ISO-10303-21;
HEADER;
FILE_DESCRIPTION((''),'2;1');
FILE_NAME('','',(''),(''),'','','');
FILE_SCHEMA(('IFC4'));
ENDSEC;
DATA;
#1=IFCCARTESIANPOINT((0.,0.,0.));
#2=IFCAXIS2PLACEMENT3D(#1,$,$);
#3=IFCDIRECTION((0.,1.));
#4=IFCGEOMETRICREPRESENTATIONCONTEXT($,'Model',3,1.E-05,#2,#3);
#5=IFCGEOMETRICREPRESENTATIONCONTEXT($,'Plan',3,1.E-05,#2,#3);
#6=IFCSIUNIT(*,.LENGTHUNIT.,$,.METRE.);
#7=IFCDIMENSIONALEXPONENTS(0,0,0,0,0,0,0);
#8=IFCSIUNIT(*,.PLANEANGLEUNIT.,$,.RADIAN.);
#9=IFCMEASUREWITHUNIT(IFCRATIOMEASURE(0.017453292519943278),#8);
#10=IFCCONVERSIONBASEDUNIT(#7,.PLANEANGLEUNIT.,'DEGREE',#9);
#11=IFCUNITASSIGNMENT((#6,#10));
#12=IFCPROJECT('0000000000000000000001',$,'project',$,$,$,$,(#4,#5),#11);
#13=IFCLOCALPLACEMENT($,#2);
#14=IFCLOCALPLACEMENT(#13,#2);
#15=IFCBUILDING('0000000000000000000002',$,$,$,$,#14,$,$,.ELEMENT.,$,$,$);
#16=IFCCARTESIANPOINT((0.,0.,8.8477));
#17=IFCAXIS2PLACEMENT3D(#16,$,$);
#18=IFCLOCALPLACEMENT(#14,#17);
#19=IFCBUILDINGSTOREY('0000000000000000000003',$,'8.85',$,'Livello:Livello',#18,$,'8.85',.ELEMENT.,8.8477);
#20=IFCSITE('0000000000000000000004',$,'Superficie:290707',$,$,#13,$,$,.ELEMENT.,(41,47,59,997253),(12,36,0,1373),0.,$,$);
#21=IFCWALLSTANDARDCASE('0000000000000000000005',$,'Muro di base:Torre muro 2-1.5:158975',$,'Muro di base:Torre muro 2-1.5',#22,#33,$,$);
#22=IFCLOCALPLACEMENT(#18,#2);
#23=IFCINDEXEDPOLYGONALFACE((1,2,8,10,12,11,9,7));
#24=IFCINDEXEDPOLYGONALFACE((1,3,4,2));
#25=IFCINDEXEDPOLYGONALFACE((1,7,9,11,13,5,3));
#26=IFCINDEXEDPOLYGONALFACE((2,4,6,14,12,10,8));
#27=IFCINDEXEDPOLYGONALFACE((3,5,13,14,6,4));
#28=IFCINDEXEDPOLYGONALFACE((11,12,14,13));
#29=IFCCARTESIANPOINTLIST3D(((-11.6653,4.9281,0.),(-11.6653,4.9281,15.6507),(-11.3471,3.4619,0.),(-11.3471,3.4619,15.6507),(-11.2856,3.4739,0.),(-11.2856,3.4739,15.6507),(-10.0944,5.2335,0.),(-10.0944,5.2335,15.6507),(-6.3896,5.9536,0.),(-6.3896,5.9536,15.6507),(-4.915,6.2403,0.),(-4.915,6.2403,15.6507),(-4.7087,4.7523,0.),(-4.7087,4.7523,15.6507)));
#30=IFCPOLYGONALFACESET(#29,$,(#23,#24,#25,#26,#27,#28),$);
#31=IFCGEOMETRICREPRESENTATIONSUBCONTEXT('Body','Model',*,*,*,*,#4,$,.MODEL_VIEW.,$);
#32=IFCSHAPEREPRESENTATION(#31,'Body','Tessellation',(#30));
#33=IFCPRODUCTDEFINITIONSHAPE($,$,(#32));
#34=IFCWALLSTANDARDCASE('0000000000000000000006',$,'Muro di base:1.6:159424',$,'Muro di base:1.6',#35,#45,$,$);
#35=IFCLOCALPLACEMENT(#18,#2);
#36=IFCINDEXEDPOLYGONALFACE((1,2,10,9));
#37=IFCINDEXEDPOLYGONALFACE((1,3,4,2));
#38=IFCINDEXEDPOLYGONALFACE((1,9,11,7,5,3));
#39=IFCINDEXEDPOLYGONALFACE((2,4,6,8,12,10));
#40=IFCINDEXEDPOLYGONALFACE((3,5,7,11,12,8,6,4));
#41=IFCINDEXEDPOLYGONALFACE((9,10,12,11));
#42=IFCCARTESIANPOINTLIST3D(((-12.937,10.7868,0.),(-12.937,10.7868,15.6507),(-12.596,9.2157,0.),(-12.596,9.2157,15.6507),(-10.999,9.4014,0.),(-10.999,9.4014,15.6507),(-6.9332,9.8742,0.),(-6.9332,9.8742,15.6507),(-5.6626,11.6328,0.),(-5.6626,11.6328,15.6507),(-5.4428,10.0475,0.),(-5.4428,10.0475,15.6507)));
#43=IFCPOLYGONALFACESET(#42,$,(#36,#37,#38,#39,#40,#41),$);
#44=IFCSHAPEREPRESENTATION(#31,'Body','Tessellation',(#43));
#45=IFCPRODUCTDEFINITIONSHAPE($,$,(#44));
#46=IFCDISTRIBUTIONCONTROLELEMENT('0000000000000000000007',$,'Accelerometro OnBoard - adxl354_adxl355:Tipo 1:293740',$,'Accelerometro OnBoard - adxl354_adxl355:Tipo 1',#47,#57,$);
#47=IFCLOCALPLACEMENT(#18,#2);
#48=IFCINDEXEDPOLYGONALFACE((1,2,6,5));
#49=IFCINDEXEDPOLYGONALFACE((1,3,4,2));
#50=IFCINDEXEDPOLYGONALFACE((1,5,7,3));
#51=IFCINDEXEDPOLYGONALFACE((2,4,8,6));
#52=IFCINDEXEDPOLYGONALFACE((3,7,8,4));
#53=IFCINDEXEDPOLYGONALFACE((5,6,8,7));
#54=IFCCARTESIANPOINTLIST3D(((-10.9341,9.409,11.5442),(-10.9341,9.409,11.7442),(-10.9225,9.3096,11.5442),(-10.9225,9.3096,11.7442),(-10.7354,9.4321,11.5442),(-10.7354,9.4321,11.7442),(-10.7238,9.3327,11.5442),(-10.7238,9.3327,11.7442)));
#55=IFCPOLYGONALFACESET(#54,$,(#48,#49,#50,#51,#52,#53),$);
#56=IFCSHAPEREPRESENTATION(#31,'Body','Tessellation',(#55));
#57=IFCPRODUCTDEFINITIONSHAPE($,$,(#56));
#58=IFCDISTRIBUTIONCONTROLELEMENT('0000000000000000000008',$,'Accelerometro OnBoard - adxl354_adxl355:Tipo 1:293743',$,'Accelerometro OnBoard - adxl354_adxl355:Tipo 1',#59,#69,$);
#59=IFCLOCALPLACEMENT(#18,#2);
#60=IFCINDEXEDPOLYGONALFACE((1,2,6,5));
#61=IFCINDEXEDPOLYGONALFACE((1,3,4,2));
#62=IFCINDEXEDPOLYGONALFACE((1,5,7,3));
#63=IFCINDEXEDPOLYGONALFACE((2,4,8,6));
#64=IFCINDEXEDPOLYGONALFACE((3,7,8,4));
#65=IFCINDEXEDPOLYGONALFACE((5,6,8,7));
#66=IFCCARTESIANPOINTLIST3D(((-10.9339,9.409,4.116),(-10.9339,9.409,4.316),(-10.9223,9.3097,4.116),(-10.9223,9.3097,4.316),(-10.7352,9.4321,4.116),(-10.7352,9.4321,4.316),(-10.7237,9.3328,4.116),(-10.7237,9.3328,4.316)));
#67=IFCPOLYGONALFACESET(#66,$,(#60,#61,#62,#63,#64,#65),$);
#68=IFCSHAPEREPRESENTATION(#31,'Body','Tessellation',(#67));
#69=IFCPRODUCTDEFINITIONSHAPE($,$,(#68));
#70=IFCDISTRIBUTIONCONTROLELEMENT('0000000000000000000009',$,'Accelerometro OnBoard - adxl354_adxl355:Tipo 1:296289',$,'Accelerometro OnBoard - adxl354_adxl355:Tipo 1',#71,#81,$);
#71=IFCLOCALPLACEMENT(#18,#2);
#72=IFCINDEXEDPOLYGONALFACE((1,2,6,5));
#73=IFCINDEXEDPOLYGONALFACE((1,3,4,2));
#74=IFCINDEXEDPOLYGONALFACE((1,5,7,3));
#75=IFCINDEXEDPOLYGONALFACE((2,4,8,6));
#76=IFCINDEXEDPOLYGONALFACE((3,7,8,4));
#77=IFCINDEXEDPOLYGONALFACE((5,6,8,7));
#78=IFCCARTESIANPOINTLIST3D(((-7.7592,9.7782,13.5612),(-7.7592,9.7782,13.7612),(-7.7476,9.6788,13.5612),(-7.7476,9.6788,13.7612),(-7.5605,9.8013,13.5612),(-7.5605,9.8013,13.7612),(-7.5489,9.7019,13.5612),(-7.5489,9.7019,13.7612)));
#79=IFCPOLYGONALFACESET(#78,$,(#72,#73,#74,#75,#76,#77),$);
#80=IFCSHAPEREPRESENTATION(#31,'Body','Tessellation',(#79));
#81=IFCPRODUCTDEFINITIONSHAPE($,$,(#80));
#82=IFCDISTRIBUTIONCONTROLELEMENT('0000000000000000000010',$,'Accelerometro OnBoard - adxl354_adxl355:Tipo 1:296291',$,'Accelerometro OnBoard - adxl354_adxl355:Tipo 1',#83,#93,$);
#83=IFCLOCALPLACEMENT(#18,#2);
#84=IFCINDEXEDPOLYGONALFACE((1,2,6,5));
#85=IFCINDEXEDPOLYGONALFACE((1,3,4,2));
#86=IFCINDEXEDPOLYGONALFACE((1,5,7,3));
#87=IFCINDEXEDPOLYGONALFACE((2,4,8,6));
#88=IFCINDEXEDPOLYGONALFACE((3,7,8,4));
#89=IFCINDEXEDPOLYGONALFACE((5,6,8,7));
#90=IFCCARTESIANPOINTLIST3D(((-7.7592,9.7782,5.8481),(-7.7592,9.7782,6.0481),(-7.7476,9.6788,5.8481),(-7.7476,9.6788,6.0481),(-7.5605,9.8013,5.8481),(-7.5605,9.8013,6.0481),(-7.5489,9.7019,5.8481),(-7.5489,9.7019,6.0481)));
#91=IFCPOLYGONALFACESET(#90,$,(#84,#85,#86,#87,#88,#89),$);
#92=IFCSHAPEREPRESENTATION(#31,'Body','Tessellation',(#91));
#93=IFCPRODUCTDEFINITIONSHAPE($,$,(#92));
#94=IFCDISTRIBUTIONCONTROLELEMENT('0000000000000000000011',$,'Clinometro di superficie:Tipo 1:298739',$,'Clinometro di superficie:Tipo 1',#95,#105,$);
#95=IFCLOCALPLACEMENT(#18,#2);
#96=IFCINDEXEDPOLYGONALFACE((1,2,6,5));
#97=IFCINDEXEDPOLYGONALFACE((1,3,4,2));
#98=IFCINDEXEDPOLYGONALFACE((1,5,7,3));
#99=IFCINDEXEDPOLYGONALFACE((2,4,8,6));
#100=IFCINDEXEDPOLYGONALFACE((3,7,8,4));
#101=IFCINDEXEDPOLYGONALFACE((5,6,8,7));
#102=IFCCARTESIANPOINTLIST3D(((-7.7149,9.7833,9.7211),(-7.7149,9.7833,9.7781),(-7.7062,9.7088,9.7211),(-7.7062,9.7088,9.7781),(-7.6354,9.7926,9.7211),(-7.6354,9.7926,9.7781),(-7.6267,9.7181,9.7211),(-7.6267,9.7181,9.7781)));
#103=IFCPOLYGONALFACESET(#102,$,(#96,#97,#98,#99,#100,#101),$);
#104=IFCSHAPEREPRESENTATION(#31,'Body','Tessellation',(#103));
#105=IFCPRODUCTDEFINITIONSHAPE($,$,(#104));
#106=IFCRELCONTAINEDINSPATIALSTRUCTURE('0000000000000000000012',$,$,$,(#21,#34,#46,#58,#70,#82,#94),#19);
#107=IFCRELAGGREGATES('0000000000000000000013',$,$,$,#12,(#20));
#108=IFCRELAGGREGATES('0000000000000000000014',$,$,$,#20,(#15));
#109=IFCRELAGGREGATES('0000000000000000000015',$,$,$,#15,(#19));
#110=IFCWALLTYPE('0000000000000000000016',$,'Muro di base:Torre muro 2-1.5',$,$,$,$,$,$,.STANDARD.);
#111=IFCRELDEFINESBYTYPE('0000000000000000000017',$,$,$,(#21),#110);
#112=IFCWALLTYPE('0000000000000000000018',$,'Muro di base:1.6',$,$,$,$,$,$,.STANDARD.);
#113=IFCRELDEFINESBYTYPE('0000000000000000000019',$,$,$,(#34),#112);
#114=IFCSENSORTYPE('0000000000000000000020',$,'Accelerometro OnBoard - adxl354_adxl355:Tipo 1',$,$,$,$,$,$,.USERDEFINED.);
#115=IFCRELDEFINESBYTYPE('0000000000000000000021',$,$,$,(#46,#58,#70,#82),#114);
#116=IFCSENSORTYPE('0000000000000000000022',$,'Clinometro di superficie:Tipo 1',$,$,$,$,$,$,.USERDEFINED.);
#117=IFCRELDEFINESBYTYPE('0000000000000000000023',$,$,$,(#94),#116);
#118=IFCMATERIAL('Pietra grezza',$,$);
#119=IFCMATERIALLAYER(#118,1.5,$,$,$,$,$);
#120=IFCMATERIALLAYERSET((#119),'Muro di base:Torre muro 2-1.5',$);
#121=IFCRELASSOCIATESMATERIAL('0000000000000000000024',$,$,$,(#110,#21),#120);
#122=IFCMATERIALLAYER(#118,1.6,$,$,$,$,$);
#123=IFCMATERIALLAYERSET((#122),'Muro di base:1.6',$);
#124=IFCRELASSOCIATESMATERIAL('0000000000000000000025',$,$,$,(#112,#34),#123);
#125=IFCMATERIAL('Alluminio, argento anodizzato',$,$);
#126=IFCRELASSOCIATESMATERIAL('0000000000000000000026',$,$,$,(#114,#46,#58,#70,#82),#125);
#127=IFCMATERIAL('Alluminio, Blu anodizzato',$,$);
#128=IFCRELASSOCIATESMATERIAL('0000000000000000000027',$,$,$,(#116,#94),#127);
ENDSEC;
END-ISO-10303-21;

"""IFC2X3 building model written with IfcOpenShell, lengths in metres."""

from ifc_helpers import new_model, entity, si_unit, converted_unit, direction, frame, frame_2d, origin, place, context, subcontext, project, spatial, polyline, rectangle, outline, extrude, source, transform, mapped, material, layer, layer_set, layer_usage, type_object, type_shapes, element, save


model = new_model("IFC2X3")

# Units and contexts
model_context = context("Model", 3, precision=1e-05, world=origin(), true_north=direction((0.0, 1.0)))
plan_context = context("Plan", 3, precision=1e-05, world=origin(), true_north=direction((0.0, 1.0)))
body_context = subcontext(model_context, "Body", "Model", "MODEL_VIEW")
ifc_project = project(units=[si_unit("LENGTHUNIT", "METRE"), converted_unit("PLANEANGLEUNIT", "DEGREE", entity("IfcRatioMeasure", 0.017453292519943278), si_unit("PLANEANGLEUNIT", "RADIAN"), dimensions=[0, 0, 0, 0, 0, 0, 0])], contexts=[model_context, plan_context])

# Site, building, storey
site_placement = place(None, origin())
site = spatial("IfcSite", under=ifc_project, at=site_placement, Name="Superficie:290707", CompositionType="ELEMENT", RefLatitude=(41, 47, 59, 997253), RefLongitude=(12, 36, 0, 1373), RefElevation=0.0)
building_placement = place(site_placement, origin())
building = spatial("IfcBuilding", under=site, at=building_placement, CompositionType="ELEMENT")
storey_placement = place(building_placement, frame((0.0, 0.0, 8.8477)))
storey = spatial("IfcBuildingStorey", under=building, at=storey_placement, Name="8.85", ObjectType="Livello:Livello", LongName="8.85", CompositionType="ELEMENT", Elevation=8.8477)

# Walls
ifc_material_1 = material(Name="Pietra grezza")
ifc_layer_1 = layer(ifc_material_1, 1.5)
ifc_layer_set_1 = layer_set([ifc_layer_1], Name="Muro di base:Torre muro 2-1.5")
ifc_layer_usage_1 = layer_usage(ifc_layer_set_1, "AXIS2", "NEGATIVE", 0.75)
wall_type_1 = type_object("IfcWallType", Name="Muro di base:Torre muro 2-1.5", PredefinedType="STANDARD", material=ifc_layer_set_1)
wall_1_placement = place(storey_placement, frame((-4.7719, 5.5041, 0.0), z_axis=(0.0, 0.0, 1.0), x_axis=(-0.981627, -0.190809, 0.0)))
element("IfcWallStandardCase", 1, at=wall_1_placement, inside=storey, type_object=wall_type_1, material=ifc_layer_usage_1, Name="Muro di base:Torre muro 2-1.5:158975", ObjectType="Muro di base:Torre muro 2-1.5", context=body_context, shape_type="SweptSolid", body=[
    extrude(outline(polyline([(6.8767, -0.75), (6.8441, 0.75), (6.7814, 0.75), (0.0814, 0.75), (0.0, -0.75), (1.5022, -0.75), (5.2763, -0.75), (6.8767, -0.75)])), origin(), (0.0, 0.0, 1.0), 15.6507),
])
ifc_layer_2 = layer(ifc_material_1, 1.6)
ifc_layer_set_2 = layer_set([ifc_layer_2], Name="Muro di base:1.6")
wall_type_2 = type_object("IfcWallType", Name="Muro di base:1.6", PredefinedType="STANDARD", material=ifc_layer_set_2)
ifc_layer_usage_2 = layer_usage(ifc_layer_set_2, "AXIS2", "NEGATIVE", 0.8)
wall_2_placement = place(storey_placement, frame((-12.8446, 9.9922, 0.0), z_axis=(0.0, 0.0, 1.0), x_axis=(0.993306, 0.115509, 0.0)))
element("IfcWallStandardCase", 2, at=wall_2_placement, inside=storey, type_object=wall_type_2, material=ifc_layer_usage_2, Name="Muro di base:1.6:159424", ObjectType="Muro di base:1.6", context=body_context, shape_type="SweptSolid", body=[
    extrude(outline(polyline([(7.3586, -0.8), (7.3234, 0.8), (0.0, 0.8), (0.1573, -0.8), (1.765, -0.8), (5.8582, -0.8), (7.3586, -0.8)])), origin(), (0.0, 0.0, 1.0), 15.6507),
])

# Distribution control elements
ifc_material_2 = material(Name="Alluminio, argento anodizzato")
sensor_type_1 = type_object("IfcSensorType", Name="Accelerometro OnBoard - adxl354_adxl355:Tipo 1", PredefinedType="USERDEFINED", material=ifc_material_2)
shared_shape_1 = source(origin(), body_context, "Body", "SweptSolid", [
    extrude(rectangle(XDim=0.2, YDim=0.1, at=frame_2d((0.0, 0.0), x_axis=(1.0, 0.0))), frame((0.1, 0.05, 0.0), z_axis=(0.0, 0.0, 1.0), x_axis=(-1.0, 0.0, 0.0)), (0.0, 0.0, 1.0), 0.2),
])
type_shapes(sensor_type_1, [shared_shape_1])
for number, where, z_axis, x_axis, name in (
    (3, (-10.7354, 9.4321, 11.5442), (0.0, 0.0, 1.0), (-0.993306, -0.115509, 0.0), "Accelerometro OnBoard - adxl354_adxl355:Tipo 1:293740"),
    (4, (-10.7352, 9.4321, 4.116), (0.0, 0.0, 1.0), (-0.993306, -0.115509, 0.0), "Accelerometro OnBoard - adxl354_adxl355:Tipo 1:293743"),
    (5, (-7.5605, 9.8013, 13.5612), (0.0, 0.0, 1.0), (-0.993306, -0.115509, 0.0), "Accelerometro OnBoard - adxl354_adxl355:Tipo 1:296289"),
    (6, (-7.5605, 9.8013, 5.8481), (0.0, 0.0, 1.0), (-0.993306, -0.115509, 0.0), "Accelerometro OnBoard - adxl354_adxl355:Tipo 1:296291"),
):
    element("IfcDistributionControlElement", number, at=place(storey_placement, frame(where, z_axis=z_axis, x_axis=x_axis)), inside=storey, type_object=sensor_type_1, material=ifc_material_2, Name=name, ObjectType="Accelerometro OnBoard - adxl354_adxl355:Tipo 1", context=body_context, shape_type="MappedRepresentation", body=[
        mapped(shared_shape_1, transform((0.0, 0.0, 0.0), scale=1.0)),
    ])
ifc_material_3 = material(Name="Alluminio, Blu anodizzato")
sensor_type_2 = type_object("IfcSensorType", Name="Clinometro di superficie:Tipo 1", PredefinedType="USERDEFINED", material=ifc_material_3)
shared_shape_2 = source(origin(), body_context, "Body", "SweptSolid", [
    extrude(rectangle(XDim=0.08, YDim=0.075, at=frame_2d((0.0, 0.0), x_axis=(1.0, 0.0))), frame((0.04, 0.0375, 0.0), z_axis=(0.0, 0.0, 1.0), x_axis=(-1.0, 0.0, 0.0)), (0.0, 0.0, 1.0), 0.057),
])
type_shapes(sensor_type_2, [shared_shape_2])
distribution_control_element_placement = place(storey_placement, frame((-7.6354, 9.7926, 9.7211), z_axis=(0.0, 0.0, 1.0), x_axis=(-0.993306, -0.115509, 0.0)))
element("IfcDistributionControlElement", 7, at=distribution_control_element_placement, inside=storey, type_object=sensor_type_2, material=ifc_material_3, Name="Clinometro di superficie:Tipo 1:298739", ObjectType="Clinometro di superficie:Tipo 1", context=body_context, shape_type="MappedRepresentation", body=[
    mapped(shared_shape_2, transform((0.0, 0.0, 0.0), scale=1.0)),
])

save(model, "model.ifc")
